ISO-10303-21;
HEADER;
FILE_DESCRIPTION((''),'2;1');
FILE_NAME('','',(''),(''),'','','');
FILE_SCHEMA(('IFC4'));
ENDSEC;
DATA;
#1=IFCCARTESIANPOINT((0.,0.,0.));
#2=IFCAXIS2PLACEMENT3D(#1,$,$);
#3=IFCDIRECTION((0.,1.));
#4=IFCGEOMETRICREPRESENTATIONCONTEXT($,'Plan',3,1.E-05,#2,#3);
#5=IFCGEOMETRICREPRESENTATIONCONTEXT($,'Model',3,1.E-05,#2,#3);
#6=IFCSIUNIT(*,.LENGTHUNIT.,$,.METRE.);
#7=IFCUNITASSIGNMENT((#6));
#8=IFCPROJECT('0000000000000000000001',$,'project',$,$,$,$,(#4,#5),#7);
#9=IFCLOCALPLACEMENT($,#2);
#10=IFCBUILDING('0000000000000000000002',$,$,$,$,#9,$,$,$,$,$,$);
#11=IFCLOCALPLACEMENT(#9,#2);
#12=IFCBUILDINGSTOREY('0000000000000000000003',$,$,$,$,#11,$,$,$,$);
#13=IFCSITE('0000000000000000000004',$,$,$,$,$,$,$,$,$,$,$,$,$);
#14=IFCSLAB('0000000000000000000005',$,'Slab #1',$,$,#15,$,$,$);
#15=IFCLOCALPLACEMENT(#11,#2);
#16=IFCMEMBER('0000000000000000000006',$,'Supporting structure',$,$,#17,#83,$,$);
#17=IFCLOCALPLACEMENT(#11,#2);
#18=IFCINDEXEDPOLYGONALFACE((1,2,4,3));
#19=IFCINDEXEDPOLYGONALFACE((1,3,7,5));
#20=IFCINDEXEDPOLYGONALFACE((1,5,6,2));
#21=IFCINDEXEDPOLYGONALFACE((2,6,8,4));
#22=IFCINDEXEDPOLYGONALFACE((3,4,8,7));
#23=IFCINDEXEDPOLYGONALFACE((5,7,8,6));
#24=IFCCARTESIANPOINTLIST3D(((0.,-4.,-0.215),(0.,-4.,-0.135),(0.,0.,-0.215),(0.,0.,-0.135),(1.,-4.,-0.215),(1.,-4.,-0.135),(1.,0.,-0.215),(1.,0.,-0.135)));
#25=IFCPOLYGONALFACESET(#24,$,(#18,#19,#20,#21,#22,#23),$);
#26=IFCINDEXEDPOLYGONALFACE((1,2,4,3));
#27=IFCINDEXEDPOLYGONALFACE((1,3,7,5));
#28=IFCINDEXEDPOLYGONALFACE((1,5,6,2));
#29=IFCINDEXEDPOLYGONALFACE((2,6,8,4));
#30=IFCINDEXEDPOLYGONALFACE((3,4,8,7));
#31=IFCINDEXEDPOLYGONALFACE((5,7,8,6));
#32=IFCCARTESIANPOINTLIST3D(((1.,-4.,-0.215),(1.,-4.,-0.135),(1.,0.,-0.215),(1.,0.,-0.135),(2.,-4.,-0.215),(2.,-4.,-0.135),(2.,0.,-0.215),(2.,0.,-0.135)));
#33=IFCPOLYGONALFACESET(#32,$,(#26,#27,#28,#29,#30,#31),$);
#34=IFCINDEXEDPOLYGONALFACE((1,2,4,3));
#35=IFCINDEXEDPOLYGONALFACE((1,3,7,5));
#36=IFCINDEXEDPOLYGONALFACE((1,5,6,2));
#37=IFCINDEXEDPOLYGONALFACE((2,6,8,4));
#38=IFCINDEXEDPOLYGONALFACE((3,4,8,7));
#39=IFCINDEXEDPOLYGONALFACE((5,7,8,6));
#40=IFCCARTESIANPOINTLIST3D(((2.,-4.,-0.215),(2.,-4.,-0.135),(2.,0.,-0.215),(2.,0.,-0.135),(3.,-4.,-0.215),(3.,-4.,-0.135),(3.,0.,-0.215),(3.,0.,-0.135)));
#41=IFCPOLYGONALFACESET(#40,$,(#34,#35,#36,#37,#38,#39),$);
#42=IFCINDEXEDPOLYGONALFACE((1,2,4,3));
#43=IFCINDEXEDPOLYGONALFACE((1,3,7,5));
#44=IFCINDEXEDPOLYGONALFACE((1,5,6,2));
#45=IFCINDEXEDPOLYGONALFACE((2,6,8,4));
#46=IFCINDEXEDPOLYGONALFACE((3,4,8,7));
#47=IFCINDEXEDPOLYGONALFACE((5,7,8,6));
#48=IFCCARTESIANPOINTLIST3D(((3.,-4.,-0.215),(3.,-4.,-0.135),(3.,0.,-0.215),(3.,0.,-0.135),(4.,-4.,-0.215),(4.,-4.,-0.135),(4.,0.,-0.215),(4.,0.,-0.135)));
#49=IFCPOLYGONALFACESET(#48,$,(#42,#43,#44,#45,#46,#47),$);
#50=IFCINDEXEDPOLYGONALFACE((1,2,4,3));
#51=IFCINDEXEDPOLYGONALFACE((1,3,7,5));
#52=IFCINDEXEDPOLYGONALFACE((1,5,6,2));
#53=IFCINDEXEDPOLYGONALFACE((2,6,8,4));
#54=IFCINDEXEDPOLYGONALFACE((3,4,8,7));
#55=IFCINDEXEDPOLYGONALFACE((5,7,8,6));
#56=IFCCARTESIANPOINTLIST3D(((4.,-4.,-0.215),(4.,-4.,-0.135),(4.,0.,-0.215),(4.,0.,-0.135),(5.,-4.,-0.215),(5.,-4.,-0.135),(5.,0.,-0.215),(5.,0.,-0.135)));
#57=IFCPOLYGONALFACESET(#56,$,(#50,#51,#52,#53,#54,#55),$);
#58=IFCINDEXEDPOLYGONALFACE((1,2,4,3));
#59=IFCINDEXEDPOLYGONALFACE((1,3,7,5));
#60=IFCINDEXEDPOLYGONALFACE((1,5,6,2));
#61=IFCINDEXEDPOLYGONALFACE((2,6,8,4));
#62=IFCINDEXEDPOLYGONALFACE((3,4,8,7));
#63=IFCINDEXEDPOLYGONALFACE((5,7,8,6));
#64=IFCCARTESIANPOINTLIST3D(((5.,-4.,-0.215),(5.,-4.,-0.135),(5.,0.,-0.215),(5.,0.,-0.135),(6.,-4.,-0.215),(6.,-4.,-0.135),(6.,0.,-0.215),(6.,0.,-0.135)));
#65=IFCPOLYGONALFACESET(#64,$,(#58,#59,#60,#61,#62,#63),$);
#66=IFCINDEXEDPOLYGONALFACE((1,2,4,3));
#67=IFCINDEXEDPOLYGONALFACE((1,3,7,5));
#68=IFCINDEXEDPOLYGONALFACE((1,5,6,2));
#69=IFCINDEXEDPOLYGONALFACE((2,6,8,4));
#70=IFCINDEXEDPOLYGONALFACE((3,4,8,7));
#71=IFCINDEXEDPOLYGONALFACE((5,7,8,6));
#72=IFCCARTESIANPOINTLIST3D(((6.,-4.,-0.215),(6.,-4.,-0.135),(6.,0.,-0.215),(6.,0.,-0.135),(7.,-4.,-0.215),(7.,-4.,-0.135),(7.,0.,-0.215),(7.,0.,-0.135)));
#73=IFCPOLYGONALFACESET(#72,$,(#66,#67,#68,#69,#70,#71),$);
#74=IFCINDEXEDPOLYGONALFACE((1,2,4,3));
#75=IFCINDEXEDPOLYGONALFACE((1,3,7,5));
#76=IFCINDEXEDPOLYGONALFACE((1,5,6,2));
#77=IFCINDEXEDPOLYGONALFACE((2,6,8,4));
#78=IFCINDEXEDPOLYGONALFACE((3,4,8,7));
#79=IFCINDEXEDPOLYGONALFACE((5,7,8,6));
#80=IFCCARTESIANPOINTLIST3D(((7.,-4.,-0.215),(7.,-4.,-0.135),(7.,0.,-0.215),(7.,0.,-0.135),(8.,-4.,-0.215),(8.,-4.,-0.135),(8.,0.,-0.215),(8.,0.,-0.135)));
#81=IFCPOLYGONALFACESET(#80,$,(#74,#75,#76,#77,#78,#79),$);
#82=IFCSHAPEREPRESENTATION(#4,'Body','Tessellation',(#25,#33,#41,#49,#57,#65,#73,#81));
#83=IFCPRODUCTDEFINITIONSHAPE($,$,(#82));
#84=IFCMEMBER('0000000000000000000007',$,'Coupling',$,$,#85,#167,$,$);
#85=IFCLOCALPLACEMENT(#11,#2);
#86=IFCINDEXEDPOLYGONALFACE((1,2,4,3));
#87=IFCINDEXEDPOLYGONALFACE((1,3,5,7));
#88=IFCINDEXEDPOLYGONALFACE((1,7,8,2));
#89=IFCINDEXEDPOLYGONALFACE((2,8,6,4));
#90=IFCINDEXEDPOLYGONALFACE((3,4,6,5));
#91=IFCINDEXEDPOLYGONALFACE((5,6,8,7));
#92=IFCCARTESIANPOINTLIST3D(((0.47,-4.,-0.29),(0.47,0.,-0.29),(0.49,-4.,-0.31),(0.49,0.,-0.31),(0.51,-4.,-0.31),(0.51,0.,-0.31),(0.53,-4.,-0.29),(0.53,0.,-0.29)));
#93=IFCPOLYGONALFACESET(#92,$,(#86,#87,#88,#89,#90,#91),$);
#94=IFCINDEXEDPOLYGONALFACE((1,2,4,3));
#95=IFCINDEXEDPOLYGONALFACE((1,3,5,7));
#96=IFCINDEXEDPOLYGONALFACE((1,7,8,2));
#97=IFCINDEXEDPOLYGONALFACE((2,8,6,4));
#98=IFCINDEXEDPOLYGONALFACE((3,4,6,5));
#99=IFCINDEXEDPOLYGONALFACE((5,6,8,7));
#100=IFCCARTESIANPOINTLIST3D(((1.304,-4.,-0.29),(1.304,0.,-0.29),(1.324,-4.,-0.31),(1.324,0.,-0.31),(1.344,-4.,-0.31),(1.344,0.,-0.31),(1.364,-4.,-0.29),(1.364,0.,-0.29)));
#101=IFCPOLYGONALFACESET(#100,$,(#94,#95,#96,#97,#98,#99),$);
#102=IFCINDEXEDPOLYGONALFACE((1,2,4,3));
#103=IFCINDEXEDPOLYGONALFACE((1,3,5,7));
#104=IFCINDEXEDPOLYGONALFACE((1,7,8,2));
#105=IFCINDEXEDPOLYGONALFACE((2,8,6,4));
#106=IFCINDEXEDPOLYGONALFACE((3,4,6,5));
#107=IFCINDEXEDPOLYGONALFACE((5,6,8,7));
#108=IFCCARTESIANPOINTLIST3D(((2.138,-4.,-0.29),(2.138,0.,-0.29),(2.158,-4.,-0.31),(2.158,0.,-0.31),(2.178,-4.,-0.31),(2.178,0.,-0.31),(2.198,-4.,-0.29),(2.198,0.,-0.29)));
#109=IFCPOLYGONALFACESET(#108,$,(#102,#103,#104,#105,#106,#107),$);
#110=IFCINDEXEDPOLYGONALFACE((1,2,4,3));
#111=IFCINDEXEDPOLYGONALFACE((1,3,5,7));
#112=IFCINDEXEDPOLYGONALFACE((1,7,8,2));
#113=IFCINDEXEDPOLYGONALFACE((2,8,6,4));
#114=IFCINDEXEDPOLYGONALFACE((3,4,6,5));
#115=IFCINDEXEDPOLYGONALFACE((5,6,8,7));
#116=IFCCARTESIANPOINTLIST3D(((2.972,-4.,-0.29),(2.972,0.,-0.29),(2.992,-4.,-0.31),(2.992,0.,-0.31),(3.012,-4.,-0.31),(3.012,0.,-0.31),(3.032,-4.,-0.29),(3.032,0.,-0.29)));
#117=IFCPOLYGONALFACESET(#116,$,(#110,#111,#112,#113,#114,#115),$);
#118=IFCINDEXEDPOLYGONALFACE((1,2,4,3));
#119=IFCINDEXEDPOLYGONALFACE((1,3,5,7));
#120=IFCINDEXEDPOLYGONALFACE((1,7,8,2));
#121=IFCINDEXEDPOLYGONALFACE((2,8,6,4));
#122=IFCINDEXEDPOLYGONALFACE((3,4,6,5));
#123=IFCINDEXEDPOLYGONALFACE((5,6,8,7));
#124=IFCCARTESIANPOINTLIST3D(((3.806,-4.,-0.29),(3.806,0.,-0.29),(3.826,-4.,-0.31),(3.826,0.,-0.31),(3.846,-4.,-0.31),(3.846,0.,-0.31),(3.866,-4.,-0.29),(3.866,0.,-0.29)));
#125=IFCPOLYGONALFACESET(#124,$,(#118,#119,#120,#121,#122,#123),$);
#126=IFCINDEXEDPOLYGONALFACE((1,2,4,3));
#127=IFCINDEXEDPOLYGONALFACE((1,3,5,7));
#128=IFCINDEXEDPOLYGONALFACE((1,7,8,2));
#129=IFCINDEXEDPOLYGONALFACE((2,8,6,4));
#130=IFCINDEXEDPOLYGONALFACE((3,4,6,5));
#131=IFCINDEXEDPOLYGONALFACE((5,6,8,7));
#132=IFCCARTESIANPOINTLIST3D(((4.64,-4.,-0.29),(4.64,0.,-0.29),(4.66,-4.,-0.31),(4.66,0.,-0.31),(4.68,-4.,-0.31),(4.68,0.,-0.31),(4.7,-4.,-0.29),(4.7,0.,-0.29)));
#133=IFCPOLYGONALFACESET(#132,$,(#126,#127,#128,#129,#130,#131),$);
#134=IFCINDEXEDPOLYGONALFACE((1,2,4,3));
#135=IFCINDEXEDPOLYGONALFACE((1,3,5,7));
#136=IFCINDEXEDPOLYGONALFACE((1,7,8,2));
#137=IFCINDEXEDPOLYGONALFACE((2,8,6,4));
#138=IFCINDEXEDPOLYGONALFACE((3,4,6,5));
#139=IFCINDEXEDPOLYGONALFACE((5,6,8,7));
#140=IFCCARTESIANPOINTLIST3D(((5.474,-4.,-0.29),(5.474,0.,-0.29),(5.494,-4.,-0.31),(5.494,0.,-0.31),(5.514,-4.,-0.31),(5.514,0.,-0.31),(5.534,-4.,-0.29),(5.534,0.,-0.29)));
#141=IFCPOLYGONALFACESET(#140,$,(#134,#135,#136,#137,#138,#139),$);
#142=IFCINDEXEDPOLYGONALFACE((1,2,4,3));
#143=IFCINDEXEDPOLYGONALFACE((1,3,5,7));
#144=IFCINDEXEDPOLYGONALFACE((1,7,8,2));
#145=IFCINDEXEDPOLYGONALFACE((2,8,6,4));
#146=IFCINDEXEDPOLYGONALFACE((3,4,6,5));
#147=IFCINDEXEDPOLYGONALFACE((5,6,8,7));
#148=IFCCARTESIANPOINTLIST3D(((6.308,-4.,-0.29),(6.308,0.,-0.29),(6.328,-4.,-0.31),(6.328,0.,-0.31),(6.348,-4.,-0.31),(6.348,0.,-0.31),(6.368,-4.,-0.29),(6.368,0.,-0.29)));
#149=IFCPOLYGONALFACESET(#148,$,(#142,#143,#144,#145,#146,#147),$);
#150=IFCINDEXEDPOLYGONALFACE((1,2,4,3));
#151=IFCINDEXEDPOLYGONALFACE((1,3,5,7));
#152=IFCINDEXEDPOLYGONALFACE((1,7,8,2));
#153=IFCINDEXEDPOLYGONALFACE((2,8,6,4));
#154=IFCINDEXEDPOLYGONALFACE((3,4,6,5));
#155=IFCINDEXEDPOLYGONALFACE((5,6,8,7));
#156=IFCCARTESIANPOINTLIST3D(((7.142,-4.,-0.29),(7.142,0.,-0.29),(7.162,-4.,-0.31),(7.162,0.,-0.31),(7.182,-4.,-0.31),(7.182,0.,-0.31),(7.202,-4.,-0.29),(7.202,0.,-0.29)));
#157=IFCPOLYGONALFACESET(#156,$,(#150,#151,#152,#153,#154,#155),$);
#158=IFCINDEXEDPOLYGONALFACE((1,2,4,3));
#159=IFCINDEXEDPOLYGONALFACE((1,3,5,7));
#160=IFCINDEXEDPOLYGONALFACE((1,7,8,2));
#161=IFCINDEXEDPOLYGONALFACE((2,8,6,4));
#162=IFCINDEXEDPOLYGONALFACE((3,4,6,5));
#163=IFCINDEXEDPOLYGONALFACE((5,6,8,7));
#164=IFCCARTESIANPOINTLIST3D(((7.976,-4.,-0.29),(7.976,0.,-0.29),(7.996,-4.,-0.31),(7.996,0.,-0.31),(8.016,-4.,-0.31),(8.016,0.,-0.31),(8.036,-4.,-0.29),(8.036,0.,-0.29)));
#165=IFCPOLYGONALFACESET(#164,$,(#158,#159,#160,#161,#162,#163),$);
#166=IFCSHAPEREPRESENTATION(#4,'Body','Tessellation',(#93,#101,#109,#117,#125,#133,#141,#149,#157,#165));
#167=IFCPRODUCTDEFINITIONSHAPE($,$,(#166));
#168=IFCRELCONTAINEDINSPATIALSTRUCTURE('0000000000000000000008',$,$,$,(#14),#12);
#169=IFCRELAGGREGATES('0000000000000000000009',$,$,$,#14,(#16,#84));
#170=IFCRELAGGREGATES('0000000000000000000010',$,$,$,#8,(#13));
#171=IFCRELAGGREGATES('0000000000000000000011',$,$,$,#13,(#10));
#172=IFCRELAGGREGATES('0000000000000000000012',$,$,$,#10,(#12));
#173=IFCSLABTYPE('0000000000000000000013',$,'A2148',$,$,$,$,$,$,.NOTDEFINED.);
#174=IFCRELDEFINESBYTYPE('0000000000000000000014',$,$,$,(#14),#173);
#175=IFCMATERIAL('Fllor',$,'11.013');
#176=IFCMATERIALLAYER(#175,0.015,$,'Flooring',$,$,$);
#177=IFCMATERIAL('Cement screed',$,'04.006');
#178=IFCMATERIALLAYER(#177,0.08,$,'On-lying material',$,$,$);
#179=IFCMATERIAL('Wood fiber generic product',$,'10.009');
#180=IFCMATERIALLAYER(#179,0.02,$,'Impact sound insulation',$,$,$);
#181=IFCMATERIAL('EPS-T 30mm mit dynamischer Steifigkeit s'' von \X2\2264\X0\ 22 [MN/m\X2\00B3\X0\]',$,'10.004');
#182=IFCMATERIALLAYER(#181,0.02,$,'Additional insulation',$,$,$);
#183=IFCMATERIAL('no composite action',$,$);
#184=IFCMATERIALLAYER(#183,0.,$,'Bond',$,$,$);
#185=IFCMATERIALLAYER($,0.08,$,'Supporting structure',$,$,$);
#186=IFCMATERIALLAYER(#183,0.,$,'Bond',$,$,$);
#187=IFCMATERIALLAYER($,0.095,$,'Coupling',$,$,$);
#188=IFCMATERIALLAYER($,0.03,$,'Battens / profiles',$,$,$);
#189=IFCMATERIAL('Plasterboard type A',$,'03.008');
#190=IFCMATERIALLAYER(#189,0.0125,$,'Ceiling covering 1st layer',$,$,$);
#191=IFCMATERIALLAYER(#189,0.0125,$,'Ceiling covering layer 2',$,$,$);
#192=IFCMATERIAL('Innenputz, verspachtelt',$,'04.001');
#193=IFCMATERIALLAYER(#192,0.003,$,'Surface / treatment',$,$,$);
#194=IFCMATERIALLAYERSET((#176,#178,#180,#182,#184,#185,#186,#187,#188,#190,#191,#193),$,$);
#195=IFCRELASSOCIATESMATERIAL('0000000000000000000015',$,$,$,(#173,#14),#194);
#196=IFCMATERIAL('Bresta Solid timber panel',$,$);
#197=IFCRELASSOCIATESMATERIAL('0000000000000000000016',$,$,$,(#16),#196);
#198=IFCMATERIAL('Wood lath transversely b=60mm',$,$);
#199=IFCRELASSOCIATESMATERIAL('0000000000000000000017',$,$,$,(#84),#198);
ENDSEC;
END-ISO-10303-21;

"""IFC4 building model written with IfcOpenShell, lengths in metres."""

from ifc_helpers import new_model, si_unit, direction, frame, frame_2d, origin, place, context, project, spatial, polyline, rectangle, outline, extrude, material, layer, layer_set, type_object, element, aggregate, save


model = new_model("IFC4")

# Units and contexts
plan_context = context("Plan", 3, precision=1e-05, world=origin(), true_north=direction((0.0, 1.0)))
model_context = context("Model", 3, precision=1e-05, world=origin(), true_north=direction((0.0, 1.0)))
ifc_project = project(units=[si_unit("LENGTHUNIT", "METRE")], contexts=[plan_context, model_context])

# Site, building, storey
site = spatial("IfcSite", under=ifc_project)
building_placement = place(None, origin())
building = spatial("IfcBuilding", under=site, at=building_placement)
storey_placement = place(building_placement, origin())
storey = spatial("IfcBuildingStorey", under=building, at=storey_placement)

# Slab, members
ifc_material_1 = material(Name="Fllor", Category="11.013")
ifc_layer_1 = layer(ifc_material_1, 0.015, Name="Flooring")
ifc_material_2 = material(Name="Cement screed", Category="04.006")
ifc_layer_2 = layer(ifc_material_2, 0.08, Name="On-lying material")
ifc_material_3 = material(Name="Wood fiber generic product", Category="10.009")
ifc_layer_3 = layer(ifc_material_3, 0.02, Name="Impact sound insulation")
ifc_material_4 = material(Name="EPS-T 30mm mit dynamischer Steifigkeit s' von ≤ 22 [MN/m³]", Category="10.004")
ifc_layer_4 = layer(ifc_material_4, 0.02, Name="Additional insulation")
ifc_material_5 = material(Name="no composite action")
ifc_layer_5 = layer(ifc_material_5, 0.0, Name="Bond")
ifc_layer_6 = layer(None, 0.08, Name="Supporting structure")
ifc_layer_7 = layer(ifc_material_5, 0.0, Name="Bond")
ifc_layer_8 = layer(None, 0.095, Name="Coupling")
ifc_layer_9 = layer(None, 0.03, Name="Battens / profiles")
ifc_material_6 = material(Name="Plasterboard type A", Category="03.008")
ifc_layer_10 = layer(ifc_material_6, 0.0125, Name="Ceiling covering 1st layer")
ifc_layer_11 = layer(ifc_material_6, 0.0125, Name="Ceiling covering layer 2")
ifc_material_7 = material(Name="Innenputz, verspachtelt", Category="04.001")
ifc_layer_12 = layer(ifc_material_7, 0.003, Name="Surface / treatment")
ifc_layer_set = layer_set([ifc_layer_1, ifc_layer_2, ifc_layer_3, ifc_layer_4, ifc_layer_5, ifc_layer_6, ifc_layer_7, ifc_layer_8, ifc_layer_9, ifc_layer_10, ifc_layer_11, ifc_layer_12])
slab_type = type_object("IfcSlabType", Name="A2148", PredefinedType="NOTDEFINED", material=ifc_layer_set)
slab_placement = place(None, frame((0.0, 0.0, 0.0), z_axis=(0.0, 0.0, -1.0), x_axis=(1.0, 0.0, 0.0)))
slab = element("IfcSlab", 1, at=slab_placement, inside=storey, type_object=slab_type, material=ifc_layer_set, Name="Slab #1")
ifc_material_8 = material(Name="Bresta Solid timber panel")
member_1_placement = place(slab_placement, origin())
member_1 = element("IfcMember", 2, at=member_1_placement, material=ifc_material_8, Name="Supporting structure", context=plan_context, shape_type="SweptSolid", body=[
    extrude(rectangle(XDim=1.0, YDim=0.08, at=frame_2d((0.5, 0.04), x_axis=(1.0, 0.0))), frame((0.0, 4.0, 0.135), z_axis=(0.0, -1.0, 0.0), x_axis=(1.0, 0.0, 0.0)), (0.0, 0.0, 1.0), 4.0),
    extrude(rectangle(XDim=1.0, YDim=0.08, at=frame_2d((0.5, 0.04), x_axis=(1.0, 0.0))), frame((1.0, 4.0, 0.135), z_axis=(0.0, -1.0, 0.0), x_axis=(1.0, 0.0, 0.0)), (0.0, 0.0, 1.0), 4.0),
    extrude(rectangle(XDim=1.0, YDim=0.08, at=frame_2d((0.5, 0.04), x_axis=(1.0, 0.0))), frame((2.0, 4.0, 0.135), z_axis=(0.0, -1.0, 0.0), x_axis=(1.0, 0.0, 0.0)), (0.0, 0.0, 1.0), 4.0),
    extrude(rectangle(XDim=1.0, YDim=0.08, at=frame_2d((0.5, 0.04), x_axis=(1.0, 0.0))), frame((3.0, 4.0, 0.135), z_axis=(0.0, -1.0, 0.0), x_axis=(1.0, 0.0, 0.0)), (0.0, 0.0, 1.0), 4.0),
    extrude(rectangle(XDim=1.0, YDim=0.08, at=frame_2d((0.5, 0.04), x_axis=(1.0, 0.0))), frame((4.0, 4.0, 0.135), z_axis=(0.0, -1.0, 0.0), x_axis=(1.0, 0.0, 0.0)), (0.0, 0.0, 1.0), 4.0),
    extrude(rectangle(XDim=1.0, YDim=0.08, at=frame_2d((0.5, 0.04), x_axis=(1.0, 0.0))), frame((5.0, 4.0, 0.135), z_axis=(0.0, -1.0, 0.0), x_axis=(1.0, 0.0, 0.0)), (0.0, 0.0, 1.0), 4.0),
    extrude(rectangle(XDim=1.0, YDim=0.08, at=frame_2d((0.5, 0.04), x_axis=(1.0, 0.0))), frame((6.0, 4.0, 0.135), z_axis=(0.0, -1.0, 0.0), x_axis=(1.0, 0.0, 0.0)), (0.0, 0.0, 1.0), 4.0),
    extrude(rectangle(XDim=1.0, YDim=0.08, at=frame_2d((0.5, 0.04), x_axis=(1.0, 0.0))), frame((7.0, 4.0, 0.135), z_axis=(0.0, -1.0, 0.0), x_axis=(1.0, 0.0, 0.0)), (0.0, 0.0, 1.0), 4.0),
])
ifc_material_9 = material(Name="Wood lath transversely b=60mm")
member_2_placement = place(slab_placement, origin())
member_2 = element("IfcMember", 3, at=member_2_placement, material=ifc_material_9, Name="Coupling", context=plan_context, shape_type="SweptSolid", body=[
    extrude(outline(polyline([(0.0, 0.0), (0.06, 0.0), (0.04, 0.02), (0.02, 0.02), (0.0, 0.0)])), frame((0.47, 4.0, 0.29), z_axis=(0.0, -1.0, 0.0), x_axis=(1.0, 0.0, 0.0)), (0.0, 0.0, 1.0), 4.0),
    extrude(outline(polyline([(0.0, 0.0), (0.06, 0.0), (0.04, 0.02), (0.02, 0.02), (0.0, 0.0)])), frame((1.304, 4.0, 0.29), z_axis=(0.0, -1.0, 0.0), x_axis=(1.0, 0.0, 0.0)), (0.0, 0.0, 1.0), 4.0),
    extrude(outline(polyline([(0.0, 0.0), (0.06, 0.0), (0.04, 0.02), (0.02, 0.02), (0.0, 0.0)])), frame((2.138, 4.0, 0.29), z_axis=(0.0, -1.0, 0.0), x_axis=(1.0, 0.0, 0.0)), (0.0, 0.0, 1.0), 4.0),
    extrude(outline(polyline([(0.0, 0.0), (0.06, 0.0), (0.04, 0.02), (0.02, 0.02), (0.0, 0.0)])), frame((2.972, 4.0, 0.29), z_axis=(0.0, -1.0, 0.0), x_axis=(1.0, 0.0, 0.0)), (0.0, 0.0, 1.0), 4.0),
    extrude(outline(polyline([(0.0, 0.0), (0.06, 0.0), (0.04, 0.02), (0.02, 0.02), (0.0, 0.0)])), frame((3.806, 4.0, 0.29), z_axis=(0.0, -1.0, 0.0), x_axis=(1.0, 0.0, 0.0)), (0.0, 0.0, 1.0), 4.0),
    extrude(outline(polyline([(0.0, 0.0), (0.06, 0.0), (0.04, 0.02), (0.02, 0.02), (0.0, 0.0)])), frame((4.64, 4.0, 0.29), z_axis=(0.0, -1.0, 0.0), x_axis=(1.0, 0.0, 0.0)), (0.0, 0.0, 1.0), 4.0),
    extrude(outline(polyline([(0.0, 0.0), (0.06, 0.0), (0.04, 0.02), (0.02, 0.02), (0.0, 0.0)])), frame((5.474, 4.0, 0.29), z_axis=(0.0, -1.0, 0.0), x_axis=(1.0, 0.0, 0.0)), (0.0, 0.0, 1.0), 4.0),
    extrude(outline(polyline([(0.0, 0.0), (0.06, 0.0), (0.04, 0.02), (0.02, 0.02), (0.0, 0.0)])), frame((6.308, 4.0, 0.29), z_axis=(0.0, -1.0, 0.0), x_axis=(1.0, 0.0, 0.0)), (0.0, 0.0, 1.0), 4.0),
    extrude(outline(polyline([(0.0, 0.0), (0.06, 0.0), (0.04, 0.02), (0.02, 0.02), (0.0, 0.0)])), frame((7.142, 4.0, 0.29), z_axis=(0.0, -1.0, 0.0), x_axis=(1.0, 0.0, 0.0)), (0.0, 0.0, 1.0), 4.0),
    extrude(outline(polyline([(0.0, 0.0), (0.06, 0.0), (0.04, 0.02), (0.02, 0.02), (0.0, 0.0)])), frame((7.976, 4.0, 0.29), z_axis=(0.0, -1.0, 0.0), x_axis=(1.0, 0.0, 0.0)), (0.0, 0.0, 1.0), 4.0),
])
aggregate(slab, [member_1, member_2])

save(model, "model.ifc")
